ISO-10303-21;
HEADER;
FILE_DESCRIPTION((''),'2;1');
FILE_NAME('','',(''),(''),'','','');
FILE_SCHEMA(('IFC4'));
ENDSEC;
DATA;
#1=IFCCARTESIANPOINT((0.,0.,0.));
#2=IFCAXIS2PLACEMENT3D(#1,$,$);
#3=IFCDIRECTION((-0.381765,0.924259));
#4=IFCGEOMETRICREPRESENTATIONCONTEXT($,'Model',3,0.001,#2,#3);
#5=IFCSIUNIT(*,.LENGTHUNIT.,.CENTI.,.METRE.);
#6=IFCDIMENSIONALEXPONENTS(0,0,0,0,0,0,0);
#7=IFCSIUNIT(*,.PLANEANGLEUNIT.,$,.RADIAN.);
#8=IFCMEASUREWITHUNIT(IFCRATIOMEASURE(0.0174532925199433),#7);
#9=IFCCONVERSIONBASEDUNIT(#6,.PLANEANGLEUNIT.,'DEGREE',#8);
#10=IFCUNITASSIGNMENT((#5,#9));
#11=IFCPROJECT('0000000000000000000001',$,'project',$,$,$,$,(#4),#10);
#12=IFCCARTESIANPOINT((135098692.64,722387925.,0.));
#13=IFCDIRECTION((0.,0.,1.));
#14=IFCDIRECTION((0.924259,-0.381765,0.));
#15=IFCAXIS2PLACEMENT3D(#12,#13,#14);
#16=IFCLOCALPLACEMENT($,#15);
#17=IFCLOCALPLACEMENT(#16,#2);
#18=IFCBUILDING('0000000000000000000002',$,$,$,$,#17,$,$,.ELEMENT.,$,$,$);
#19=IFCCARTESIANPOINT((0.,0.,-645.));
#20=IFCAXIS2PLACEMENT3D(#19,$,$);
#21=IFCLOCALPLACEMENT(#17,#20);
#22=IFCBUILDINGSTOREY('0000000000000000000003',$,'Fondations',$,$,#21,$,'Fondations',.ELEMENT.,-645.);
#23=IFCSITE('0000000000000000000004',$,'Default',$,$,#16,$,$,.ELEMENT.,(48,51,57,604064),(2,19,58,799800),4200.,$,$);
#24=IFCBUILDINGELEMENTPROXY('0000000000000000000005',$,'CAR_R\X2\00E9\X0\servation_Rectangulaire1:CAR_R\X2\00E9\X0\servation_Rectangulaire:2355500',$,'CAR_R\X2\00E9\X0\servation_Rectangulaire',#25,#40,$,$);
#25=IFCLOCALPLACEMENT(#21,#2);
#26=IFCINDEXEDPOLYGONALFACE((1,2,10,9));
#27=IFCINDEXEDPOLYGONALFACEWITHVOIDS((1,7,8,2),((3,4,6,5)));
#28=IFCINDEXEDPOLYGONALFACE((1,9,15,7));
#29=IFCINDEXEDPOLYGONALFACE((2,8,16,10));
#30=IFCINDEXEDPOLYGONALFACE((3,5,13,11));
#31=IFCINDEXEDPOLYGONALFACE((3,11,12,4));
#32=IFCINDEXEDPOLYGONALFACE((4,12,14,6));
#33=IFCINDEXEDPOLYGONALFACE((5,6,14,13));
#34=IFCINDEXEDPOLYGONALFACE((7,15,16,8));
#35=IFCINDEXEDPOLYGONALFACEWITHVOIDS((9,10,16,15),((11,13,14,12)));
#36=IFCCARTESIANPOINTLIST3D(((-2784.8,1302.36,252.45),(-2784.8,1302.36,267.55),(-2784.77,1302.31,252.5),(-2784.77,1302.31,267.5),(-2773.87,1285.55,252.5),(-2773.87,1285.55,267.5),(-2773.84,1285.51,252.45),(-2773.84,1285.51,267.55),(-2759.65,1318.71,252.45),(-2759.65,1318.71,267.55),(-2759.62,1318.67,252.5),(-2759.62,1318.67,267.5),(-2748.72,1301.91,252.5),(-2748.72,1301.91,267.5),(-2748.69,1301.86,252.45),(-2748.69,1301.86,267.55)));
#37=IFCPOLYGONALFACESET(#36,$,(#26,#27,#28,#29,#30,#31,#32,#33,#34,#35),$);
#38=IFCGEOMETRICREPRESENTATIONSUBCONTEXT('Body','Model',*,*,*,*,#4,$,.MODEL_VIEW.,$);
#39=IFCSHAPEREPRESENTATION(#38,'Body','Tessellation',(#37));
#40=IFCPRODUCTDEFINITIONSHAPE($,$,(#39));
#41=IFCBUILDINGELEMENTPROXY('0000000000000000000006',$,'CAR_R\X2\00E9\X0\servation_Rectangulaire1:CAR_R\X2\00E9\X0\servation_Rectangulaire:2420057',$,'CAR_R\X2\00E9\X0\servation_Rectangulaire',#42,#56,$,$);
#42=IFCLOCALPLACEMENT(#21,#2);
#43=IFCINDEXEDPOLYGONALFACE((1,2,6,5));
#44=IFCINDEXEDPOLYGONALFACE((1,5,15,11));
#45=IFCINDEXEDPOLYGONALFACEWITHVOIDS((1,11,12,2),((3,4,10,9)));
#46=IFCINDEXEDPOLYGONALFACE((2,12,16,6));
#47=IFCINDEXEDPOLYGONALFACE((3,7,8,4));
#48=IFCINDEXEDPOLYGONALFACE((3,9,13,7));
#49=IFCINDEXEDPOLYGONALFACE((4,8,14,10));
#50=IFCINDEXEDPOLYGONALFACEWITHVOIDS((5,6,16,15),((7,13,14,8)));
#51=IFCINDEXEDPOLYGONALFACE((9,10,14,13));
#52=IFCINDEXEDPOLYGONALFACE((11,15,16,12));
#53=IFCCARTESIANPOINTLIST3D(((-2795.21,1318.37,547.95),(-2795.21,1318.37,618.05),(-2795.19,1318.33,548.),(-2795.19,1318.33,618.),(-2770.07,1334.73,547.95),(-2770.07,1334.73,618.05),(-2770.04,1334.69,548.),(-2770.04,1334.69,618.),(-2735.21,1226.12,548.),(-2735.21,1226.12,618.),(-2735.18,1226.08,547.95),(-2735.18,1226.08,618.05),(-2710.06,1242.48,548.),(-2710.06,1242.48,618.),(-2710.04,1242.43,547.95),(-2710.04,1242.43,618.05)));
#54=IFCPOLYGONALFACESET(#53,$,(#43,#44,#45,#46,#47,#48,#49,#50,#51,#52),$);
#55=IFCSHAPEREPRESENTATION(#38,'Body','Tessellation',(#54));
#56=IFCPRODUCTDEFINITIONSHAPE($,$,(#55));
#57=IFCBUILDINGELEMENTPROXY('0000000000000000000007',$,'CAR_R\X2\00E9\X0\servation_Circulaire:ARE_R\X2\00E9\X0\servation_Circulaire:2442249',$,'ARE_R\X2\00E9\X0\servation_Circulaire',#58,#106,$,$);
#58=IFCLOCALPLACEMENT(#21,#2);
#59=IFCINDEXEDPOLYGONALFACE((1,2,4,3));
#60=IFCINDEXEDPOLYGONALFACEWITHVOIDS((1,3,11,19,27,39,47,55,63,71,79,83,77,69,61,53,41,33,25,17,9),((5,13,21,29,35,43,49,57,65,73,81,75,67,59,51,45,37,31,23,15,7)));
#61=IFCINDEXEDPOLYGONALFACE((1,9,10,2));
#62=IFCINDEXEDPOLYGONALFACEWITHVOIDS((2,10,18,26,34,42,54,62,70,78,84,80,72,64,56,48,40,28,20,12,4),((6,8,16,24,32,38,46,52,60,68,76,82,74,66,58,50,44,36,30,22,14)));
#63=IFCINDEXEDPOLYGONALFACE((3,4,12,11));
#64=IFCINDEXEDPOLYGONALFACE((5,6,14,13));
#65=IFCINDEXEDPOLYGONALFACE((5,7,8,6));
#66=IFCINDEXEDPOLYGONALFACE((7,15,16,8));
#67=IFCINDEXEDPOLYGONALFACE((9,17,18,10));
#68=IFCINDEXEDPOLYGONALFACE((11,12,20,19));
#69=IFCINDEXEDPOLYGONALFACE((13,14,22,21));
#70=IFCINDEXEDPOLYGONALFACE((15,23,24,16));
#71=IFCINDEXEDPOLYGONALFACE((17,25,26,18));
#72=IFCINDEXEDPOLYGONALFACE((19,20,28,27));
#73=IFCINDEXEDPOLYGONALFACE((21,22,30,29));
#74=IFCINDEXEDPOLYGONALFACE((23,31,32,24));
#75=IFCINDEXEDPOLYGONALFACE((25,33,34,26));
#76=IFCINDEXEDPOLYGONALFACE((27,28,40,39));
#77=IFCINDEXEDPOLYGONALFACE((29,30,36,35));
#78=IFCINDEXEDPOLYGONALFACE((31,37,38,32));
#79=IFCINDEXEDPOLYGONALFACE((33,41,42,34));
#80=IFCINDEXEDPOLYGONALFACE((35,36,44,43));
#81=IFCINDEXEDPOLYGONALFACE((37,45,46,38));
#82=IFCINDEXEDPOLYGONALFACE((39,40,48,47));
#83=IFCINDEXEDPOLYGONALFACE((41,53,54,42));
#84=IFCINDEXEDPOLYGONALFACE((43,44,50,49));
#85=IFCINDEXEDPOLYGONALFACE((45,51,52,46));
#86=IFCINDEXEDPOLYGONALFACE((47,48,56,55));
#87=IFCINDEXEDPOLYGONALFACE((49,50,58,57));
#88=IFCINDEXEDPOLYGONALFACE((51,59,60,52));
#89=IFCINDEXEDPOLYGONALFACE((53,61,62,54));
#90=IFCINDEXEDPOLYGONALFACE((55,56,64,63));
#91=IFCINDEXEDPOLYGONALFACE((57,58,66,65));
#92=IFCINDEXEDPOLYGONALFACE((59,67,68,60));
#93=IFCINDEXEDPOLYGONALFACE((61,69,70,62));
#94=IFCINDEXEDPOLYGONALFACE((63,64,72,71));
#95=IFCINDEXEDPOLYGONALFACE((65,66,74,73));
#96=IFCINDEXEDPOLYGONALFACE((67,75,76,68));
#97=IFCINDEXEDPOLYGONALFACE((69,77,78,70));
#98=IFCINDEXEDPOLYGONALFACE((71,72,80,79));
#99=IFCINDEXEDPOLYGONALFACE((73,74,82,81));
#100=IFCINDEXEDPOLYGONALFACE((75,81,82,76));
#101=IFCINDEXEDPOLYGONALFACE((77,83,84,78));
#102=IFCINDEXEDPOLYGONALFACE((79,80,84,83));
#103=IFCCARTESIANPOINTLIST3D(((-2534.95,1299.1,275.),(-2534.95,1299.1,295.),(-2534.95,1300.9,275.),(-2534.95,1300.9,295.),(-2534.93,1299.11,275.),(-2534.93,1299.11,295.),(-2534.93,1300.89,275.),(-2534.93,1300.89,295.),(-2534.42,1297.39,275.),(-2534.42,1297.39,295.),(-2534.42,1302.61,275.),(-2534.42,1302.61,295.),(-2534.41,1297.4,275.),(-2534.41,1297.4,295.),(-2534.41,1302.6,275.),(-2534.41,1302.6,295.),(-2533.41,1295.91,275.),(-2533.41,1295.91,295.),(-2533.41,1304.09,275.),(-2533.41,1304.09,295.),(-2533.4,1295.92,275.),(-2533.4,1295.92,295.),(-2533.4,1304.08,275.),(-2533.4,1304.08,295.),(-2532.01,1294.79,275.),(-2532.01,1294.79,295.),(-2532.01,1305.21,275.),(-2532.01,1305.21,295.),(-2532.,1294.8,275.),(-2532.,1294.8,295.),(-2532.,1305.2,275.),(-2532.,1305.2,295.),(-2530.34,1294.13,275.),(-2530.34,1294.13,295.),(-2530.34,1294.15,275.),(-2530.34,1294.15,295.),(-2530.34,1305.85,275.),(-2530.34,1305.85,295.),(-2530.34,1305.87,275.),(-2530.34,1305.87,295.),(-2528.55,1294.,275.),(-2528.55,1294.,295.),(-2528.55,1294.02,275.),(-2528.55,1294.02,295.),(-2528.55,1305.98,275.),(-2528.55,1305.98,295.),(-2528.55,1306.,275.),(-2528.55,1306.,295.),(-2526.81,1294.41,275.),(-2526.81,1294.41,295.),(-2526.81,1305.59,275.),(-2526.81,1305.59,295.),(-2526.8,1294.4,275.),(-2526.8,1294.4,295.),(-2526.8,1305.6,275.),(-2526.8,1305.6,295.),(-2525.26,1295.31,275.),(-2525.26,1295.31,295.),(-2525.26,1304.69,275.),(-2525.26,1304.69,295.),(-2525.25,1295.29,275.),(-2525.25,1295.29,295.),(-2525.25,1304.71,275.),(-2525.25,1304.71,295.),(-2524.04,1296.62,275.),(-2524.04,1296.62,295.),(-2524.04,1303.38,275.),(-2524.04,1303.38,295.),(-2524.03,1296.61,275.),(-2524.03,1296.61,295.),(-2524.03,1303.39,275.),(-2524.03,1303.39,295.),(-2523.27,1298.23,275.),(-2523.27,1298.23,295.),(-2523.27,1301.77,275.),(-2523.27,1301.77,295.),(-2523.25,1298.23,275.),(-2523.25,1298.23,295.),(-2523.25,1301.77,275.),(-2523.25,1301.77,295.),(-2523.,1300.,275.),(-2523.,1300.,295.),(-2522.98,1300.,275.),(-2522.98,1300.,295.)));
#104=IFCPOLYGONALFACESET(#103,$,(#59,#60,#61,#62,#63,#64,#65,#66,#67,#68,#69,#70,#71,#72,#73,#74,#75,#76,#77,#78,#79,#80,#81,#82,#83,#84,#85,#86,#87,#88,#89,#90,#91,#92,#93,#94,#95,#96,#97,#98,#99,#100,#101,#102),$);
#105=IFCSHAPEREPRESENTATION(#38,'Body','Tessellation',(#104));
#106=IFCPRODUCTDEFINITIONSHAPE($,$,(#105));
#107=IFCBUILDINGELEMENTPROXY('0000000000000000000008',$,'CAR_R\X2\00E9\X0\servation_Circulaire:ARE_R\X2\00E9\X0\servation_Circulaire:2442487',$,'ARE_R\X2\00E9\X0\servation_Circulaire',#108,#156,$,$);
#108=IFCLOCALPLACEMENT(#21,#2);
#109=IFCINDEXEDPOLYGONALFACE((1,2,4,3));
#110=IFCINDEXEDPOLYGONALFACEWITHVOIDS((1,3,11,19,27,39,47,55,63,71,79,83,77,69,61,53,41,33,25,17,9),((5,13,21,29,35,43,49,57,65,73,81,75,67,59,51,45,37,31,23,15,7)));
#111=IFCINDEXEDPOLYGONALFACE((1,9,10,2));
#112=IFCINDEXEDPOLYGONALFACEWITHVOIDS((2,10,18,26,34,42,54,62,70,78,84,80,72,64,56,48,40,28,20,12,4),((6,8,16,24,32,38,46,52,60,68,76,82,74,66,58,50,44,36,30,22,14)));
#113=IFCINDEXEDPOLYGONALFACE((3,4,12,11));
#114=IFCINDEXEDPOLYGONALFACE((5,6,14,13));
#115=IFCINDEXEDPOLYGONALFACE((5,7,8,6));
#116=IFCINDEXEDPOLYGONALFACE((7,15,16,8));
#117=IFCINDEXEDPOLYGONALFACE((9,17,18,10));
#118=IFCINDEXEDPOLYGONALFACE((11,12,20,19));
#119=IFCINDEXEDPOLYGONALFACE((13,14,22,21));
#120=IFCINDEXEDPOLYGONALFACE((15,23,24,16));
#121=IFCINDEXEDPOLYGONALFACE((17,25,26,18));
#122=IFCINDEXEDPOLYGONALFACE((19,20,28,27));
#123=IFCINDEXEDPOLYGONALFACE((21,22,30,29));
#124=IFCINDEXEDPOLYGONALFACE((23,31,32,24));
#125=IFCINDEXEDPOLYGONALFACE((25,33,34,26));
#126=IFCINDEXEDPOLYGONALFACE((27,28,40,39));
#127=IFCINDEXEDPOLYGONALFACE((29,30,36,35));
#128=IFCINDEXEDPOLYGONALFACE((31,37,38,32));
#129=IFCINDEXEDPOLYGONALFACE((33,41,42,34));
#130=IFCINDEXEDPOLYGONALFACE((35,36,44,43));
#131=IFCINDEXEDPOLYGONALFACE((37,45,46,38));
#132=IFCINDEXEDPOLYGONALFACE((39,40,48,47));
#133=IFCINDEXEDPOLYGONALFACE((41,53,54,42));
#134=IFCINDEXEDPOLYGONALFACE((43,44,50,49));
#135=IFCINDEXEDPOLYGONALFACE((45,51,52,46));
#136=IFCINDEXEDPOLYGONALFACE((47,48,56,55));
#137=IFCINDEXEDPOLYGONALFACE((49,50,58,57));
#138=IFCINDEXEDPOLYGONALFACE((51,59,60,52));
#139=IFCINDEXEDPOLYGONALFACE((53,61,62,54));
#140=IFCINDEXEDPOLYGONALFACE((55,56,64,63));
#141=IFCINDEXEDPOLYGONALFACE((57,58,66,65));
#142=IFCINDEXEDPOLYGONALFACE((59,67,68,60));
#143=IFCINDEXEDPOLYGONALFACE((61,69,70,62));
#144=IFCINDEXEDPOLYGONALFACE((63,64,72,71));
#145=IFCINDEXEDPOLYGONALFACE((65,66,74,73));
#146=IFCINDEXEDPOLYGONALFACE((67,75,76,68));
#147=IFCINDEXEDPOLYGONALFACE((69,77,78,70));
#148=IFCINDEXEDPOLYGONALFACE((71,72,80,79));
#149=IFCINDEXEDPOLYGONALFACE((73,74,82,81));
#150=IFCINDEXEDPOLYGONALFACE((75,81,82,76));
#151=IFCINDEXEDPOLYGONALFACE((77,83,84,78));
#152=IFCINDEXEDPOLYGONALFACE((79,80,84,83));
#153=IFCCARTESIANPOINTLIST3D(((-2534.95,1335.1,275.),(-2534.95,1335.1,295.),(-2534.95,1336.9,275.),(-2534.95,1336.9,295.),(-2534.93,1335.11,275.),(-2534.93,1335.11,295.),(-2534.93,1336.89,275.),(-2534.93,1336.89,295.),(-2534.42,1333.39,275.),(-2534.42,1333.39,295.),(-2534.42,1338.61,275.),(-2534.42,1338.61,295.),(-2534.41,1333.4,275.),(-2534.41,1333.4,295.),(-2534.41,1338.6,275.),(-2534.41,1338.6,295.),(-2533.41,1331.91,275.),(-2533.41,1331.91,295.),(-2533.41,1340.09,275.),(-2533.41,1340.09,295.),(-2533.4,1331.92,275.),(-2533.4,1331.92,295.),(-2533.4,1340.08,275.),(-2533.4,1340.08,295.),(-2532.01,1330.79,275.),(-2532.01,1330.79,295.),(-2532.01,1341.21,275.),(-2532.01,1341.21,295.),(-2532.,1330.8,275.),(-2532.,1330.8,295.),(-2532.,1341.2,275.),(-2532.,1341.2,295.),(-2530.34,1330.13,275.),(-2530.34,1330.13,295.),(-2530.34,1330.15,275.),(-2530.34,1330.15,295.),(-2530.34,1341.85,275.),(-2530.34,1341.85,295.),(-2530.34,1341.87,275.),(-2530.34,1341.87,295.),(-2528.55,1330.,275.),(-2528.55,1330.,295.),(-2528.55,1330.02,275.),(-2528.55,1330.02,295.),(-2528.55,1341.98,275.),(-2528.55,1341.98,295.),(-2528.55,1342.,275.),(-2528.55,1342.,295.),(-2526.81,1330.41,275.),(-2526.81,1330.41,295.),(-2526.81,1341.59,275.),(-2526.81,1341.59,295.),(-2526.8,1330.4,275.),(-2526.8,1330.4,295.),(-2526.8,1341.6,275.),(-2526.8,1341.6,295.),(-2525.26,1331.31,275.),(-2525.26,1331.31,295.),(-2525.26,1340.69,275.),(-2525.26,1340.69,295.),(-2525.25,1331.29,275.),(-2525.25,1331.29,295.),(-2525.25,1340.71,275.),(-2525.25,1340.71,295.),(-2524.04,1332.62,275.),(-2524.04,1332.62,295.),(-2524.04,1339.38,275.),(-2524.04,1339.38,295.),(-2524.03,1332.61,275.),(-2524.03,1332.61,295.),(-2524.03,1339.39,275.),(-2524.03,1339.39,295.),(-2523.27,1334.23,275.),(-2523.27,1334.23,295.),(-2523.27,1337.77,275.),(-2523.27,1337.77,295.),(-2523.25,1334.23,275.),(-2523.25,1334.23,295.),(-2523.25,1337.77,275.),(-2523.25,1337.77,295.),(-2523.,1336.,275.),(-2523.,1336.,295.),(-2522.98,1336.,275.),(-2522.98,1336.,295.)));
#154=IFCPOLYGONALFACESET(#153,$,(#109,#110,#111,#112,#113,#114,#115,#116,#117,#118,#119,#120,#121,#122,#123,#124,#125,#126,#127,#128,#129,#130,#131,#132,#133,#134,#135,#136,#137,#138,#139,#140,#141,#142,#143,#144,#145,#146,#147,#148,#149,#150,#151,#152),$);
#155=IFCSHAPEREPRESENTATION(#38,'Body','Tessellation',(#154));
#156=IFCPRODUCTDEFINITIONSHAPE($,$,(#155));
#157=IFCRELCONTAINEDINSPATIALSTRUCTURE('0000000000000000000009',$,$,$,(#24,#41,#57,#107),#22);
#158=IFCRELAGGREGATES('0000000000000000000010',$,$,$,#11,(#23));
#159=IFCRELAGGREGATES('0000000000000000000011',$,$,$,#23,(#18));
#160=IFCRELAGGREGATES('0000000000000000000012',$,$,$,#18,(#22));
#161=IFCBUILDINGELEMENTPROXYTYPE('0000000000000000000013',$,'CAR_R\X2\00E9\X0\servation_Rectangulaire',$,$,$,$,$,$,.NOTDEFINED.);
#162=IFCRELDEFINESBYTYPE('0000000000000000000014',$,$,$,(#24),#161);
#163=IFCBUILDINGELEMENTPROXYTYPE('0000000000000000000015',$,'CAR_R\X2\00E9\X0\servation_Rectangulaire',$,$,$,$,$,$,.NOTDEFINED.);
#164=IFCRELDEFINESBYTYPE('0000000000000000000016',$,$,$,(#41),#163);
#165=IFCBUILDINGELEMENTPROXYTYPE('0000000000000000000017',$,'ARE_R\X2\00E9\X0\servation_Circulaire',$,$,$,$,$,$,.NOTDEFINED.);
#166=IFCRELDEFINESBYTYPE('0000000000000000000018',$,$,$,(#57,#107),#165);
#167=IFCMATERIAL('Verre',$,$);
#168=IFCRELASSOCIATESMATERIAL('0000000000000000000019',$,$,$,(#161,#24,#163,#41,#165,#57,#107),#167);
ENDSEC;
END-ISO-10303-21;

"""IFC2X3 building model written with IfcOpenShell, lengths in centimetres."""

from ifc_helpers import new_model, entity, si_unit, converted_unit, direction, frame, frame_2d, origin, place, context, subcontext, project, spatial, polyline, hollow_circle, outline, extrude, source, transform, mapped, material, type_object, type_shapes, element, save


model = new_model("IFC2X3")

# Units and contexts
model_context = context("Model", 3, precision=0.001, world=origin(), true_north=direction((-0.381765, 0.924259)))
body_context = subcontext(model_context, "Body", "Model", "MODEL_VIEW")
ifc_project = project(units=[si_unit("LENGTHUNIT", "METRE", prefix="CENTI"), converted_unit("PLANEANGLEUNIT", "DEGREE", entity("IfcRatioMeasure", 0.0174532925199433), si_unit("PLANEANGLEUNIT", "RADIAN"), dimensions=[0, 0, 0, 0, 0, 0, 0])], contexts=[model_context])

# Site, building, storey
site_placement = place(None, frame((135098692.64, 722387925.0, 0.0), z_axis=(0.0, 0.0, 1.0), x_axis=(0.924259, -0.381765, 0.0)))
site = spatial("IfcSite", under=ifc_project, at=site_placement, Name="Default", CompositionType="ELEMENT", RefLatitude=(48, 51, 57, 604064), RefLongitude=(2, 19, 58, 799800), RefElevation=4200.0)
building_placement = place(site_placement, origin())
building = spatial("IfcBuilding", under=site, at=building_placement, CompositionType="ELEMENT")
storey_placement = place(building_placement, frame((0.0, 0.0, -645.0)))
storey = spatial("IfcBuildingStorey", under=building, at=storey_placement, Name="Fondations", LongName="Fondations", CompositionType="ELEMENT", Elevation=-645.0)

# Building element proxies
ifc_material_1 = material(Name="Verre")
building_element_proxy_type_1 = type_object("IfcBuildingElementProxyType", Name="CAR_Réservation_Rectangulaire", PredefinedType="NOTDEFINED", material=ifc_material_1)
shared_shape_1 = source(origin(), body_context, "Body", "SweptSolid", [
    extrude(outline(polyline([(-10.05, -7.55), (10.05, -7.55), (10.05, 7.55), (-10.05, 7.55), (-10.05, -7.55)]), holes=[polyline([(10.0, -7.5), (-10.0, -7.5), (-10.0, 7.5), (10.0, 7.5), (10.0, -7.5)])]), frame((0.0, 0.0, -15.0), z_axis=(0.0, 0.0, 1.0), x_axis=(-1.0, 0.0, 0.0)), (0.0, 0.0, 1.0), 30.0),
])
type_shapes(building_element_proxy_type_1, [shared_shape_1])
proxy_1_placement = place(storey_placement, frame((-2766.74, 1302.11, 260.0), z_axis=(0.838282, 0.545236, 0.0), x_axis=(-0.545236, 0.838282, 0.0)))
element("IfcBuildingElementProxy", 1, at=proxy_1_placement, inside=storey, type_object=building_element_proxy_type_1, material=ifc_material_1, Name="CAR_Réservation_Rectangulaire1:CAR_Réservation_Rectangulaire:2355500", ObjectType="CAR_Réservation_Rectangulaire", context=body_context, shape_type="MappedRepresentation", body=[
    mapped(shared_shape_1, transform((0.0, 0.0, 0.0), scale=1.0)),
])
building_element_proxy_type_2 = type_object("IfcBuildingElementProxyType", Name="CAR_Réservation_Rectangulaire", PredefinedType="NOTDEFINED", material=ifc_material_1)
shared_shape_2 = source(origin(), body_context, "Body", "SweptSolid", [
    extrude(outline(polyline([(-55.05, -35.05), (55.05, -35.05), (55.05, 35.05), (-55.05, 35.05), (-55.05, -35.05)]), holes=[polyline([(55.0, -35.0), (-55.0, -35.0), (-55.0, 35.0), (55.0, 35.0), (55.0, -35.0)])]), frame((0.0, 0.0, -10.0), z_axis=(0.0, 0.0, 1.0), x_axis=(-1.0, 0.0, 0.0)), (0.0, 0.0, 1.0), 30.0),
])
type_shapes(building_element_proxy_type_2, [shared_shape_2])
proxy_2_placement = place(storey_placement, frame((-2748.43, 1283.13, 583.0), z_axis=(-0.838282, -0.545236, 0.0), x_axis=(0.545236, -0.838282, 0.0)))
element("IfcBuildingElementProxy", 2, at=proxy_2_placement, inside=storey, type_object=building_element_proxy_type_2, material=ifc_material_1, Name="CAR_Réservation_Rectangulaire1:CAR_Réservation_Rectangulaire:2420057", ObjectType="CAR_Réservation_Rectangulaire", context=body_context, shape_type="MappedRepresentation", body=[
    mapped(shared_shape_2, transform((0.0, 0.0, 0.0), scale=1.0)),
])
building_element_proxy_type_3 = type_object("IfcBuildingElementProxyType", Name="ARE_Réservation_Circulaire", PredefinedType="NOTDEFINED", material=ifc_material_1)
shared_shape_3 = source(origin(), body_context, "Body", "SweptSolid", [
    extrude(hollow_circle(Radius=6.02, WallThickness=0.02, at=frame_2d((0.0, 0.0), x_axis=(1.0, 0.0))), frame((0.0, 0.0, -20.0)), (0.0, 0.0, 1.0), 20.0),
])
type_shapes(building_element_proxy_type_3, [shared_shape_3])
for number, where, name in (
    (3, (-2529.0, 1300.0, 295.0), "CAR_Réservation_Circulaire:ARE_Réservation_Circulaire:2442249"),
    (4, (-2529.0, 1336.0, 295.0), "CAR_Réservation_Circulaire:ARE_Réservation_Circulaire:2442487"),
):
    element("IfcBuildingElementProxy", number, at=place(storey_placement, frame(where)), inside=storey, type_object=building_element_proxy_type_3, material=ifc_material_1, Name=name, ObjectType="ARE_Réservation_Circulaire", context=body_context, shape_type="MappedRepresentation", body=[
        mapped(shared_shape_3, transform((0.0, 0.0, 0.0), scale=1.0)),
    ])

save(model, "model.ifc")
